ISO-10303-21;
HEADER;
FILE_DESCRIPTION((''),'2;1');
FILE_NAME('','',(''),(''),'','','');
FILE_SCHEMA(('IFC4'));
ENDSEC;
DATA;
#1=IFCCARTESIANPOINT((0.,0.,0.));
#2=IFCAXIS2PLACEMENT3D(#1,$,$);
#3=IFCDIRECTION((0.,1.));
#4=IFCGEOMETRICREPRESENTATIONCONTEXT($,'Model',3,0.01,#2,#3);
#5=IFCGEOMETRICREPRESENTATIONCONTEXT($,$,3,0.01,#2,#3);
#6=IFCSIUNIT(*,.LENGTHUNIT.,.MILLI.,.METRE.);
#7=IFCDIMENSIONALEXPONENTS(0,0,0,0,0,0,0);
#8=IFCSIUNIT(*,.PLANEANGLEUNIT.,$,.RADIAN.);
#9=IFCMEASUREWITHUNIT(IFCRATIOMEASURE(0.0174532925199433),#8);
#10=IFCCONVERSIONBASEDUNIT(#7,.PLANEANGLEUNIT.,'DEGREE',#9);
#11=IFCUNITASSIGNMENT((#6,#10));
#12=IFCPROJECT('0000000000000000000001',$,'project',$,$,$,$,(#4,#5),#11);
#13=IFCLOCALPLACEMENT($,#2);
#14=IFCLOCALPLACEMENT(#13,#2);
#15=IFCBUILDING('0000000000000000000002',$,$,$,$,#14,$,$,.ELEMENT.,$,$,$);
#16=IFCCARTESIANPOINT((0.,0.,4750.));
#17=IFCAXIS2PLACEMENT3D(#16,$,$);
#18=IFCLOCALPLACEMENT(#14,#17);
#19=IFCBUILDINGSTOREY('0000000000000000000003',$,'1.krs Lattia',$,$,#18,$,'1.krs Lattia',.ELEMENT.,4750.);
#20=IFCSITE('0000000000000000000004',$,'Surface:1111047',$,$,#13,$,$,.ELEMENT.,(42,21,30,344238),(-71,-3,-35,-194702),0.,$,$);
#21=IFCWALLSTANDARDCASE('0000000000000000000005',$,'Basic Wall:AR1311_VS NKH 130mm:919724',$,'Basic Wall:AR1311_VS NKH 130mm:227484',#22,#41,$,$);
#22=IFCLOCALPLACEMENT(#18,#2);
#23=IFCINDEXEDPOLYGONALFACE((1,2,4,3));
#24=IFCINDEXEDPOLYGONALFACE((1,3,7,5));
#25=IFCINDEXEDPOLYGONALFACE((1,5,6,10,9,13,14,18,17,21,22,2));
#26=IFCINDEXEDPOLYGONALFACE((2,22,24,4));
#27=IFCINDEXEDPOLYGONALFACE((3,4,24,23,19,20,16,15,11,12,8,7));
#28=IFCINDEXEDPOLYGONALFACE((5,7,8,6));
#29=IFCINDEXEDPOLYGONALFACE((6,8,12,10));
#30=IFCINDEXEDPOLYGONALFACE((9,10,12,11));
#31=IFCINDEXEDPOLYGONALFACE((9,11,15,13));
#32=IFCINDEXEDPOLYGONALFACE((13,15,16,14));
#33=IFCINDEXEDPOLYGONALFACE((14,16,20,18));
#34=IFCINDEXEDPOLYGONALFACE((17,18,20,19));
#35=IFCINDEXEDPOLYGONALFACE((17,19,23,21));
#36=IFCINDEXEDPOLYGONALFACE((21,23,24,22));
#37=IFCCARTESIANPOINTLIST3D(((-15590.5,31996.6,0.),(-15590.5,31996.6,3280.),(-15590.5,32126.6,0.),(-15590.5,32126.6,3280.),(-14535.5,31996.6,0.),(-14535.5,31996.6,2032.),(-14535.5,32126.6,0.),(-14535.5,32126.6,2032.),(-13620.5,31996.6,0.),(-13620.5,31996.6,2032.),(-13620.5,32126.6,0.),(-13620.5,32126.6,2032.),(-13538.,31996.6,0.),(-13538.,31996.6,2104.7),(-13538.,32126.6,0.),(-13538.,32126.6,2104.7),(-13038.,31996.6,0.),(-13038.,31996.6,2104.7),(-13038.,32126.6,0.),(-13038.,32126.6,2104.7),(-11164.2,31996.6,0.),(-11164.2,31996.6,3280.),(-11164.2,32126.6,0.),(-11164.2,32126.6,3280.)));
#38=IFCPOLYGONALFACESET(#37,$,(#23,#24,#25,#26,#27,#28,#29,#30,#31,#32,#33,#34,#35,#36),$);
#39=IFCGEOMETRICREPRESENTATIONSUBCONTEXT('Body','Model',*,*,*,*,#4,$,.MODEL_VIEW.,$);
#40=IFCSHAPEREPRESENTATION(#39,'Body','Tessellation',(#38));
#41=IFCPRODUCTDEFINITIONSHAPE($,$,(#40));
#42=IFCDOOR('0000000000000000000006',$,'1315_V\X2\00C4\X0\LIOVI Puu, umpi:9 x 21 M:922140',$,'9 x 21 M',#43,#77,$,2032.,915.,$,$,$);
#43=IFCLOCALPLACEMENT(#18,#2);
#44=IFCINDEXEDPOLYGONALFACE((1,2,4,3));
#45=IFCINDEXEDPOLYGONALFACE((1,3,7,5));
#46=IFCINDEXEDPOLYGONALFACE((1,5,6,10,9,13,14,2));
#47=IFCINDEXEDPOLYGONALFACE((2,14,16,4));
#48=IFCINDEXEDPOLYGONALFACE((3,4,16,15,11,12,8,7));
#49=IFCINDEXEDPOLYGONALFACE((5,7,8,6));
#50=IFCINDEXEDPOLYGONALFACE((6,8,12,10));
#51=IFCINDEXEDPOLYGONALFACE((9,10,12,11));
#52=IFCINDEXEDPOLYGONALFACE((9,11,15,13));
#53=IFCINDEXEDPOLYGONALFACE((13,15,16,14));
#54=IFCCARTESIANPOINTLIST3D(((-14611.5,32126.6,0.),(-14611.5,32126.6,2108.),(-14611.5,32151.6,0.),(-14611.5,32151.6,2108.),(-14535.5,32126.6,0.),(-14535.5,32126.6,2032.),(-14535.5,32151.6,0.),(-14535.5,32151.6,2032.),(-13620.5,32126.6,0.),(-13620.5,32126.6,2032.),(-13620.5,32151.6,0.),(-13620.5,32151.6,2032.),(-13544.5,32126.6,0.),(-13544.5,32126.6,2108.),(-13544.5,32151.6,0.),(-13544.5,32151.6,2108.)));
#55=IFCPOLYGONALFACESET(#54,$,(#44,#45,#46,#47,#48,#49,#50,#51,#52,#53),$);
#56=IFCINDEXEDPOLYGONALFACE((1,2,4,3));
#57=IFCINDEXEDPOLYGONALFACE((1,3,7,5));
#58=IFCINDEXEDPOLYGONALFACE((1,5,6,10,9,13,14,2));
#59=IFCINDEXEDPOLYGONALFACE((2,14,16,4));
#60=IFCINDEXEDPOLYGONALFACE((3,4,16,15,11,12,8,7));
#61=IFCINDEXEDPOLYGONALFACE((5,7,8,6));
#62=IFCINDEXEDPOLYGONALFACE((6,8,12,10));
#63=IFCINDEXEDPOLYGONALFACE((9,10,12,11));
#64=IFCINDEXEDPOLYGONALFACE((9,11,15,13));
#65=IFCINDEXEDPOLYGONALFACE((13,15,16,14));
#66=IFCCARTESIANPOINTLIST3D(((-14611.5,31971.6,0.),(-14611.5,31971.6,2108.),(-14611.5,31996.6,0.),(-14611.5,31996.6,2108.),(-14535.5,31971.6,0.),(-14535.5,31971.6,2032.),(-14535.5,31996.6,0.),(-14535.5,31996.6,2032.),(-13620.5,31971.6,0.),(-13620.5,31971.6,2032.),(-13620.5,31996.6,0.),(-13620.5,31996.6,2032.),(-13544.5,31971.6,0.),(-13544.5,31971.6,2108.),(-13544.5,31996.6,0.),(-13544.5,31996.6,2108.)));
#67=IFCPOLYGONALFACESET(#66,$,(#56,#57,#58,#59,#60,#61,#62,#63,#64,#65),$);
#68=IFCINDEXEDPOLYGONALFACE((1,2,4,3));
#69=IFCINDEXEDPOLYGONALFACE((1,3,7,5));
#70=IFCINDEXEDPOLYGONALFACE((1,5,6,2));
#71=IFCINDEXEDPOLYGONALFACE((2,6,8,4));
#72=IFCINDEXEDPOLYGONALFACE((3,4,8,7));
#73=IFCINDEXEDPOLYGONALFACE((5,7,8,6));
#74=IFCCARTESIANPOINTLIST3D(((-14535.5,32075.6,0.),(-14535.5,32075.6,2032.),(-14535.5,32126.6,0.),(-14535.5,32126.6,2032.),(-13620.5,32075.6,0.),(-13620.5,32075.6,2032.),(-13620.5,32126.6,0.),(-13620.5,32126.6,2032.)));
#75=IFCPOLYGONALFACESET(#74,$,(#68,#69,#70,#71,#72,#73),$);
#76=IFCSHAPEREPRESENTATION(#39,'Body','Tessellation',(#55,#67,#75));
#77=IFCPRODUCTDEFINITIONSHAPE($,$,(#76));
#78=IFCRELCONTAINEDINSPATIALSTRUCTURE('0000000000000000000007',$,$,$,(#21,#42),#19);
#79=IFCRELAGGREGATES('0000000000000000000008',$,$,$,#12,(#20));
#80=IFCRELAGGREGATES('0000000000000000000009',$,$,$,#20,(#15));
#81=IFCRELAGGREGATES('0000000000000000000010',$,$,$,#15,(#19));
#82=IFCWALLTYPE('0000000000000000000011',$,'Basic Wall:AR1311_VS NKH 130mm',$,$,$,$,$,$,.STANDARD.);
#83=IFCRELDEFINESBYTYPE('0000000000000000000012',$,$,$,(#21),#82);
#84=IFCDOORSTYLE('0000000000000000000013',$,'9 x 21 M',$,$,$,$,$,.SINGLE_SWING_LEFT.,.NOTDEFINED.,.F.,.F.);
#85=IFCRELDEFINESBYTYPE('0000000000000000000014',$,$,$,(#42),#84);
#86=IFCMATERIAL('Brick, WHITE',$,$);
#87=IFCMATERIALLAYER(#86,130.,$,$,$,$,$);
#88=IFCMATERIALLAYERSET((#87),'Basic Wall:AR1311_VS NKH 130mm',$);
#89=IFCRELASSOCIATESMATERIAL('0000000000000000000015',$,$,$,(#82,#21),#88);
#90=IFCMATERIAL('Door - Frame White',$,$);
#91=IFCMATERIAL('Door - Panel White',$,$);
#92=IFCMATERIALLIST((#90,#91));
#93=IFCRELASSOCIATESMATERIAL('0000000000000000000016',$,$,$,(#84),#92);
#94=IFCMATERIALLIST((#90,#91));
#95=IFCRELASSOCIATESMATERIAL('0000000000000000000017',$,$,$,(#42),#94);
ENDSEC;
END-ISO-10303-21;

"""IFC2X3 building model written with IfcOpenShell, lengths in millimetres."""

from ifc_helpers import new_model, entity, si_unit, converted_unit, direction, frame, frame_2d, origin, place, context, subcontext, project, spatial, polyline, rectangle, outline, extrude, clip, bounded_halfspace, source, transform, mapped, material, material_list, layer, layer_set, layer_usage, type_object, type_shapes, element, fill, save


model = new_model("IFC2X3")

# Units and contexts
model_context = context("Model", 3, precision=0.01, world=origin(), true_north=direction((0.0, 1.0)))
context_of_model = context(None, 3, precision=0.01, world=origin(), true_north=direction((0.0, 1.0)))
body_context = subcontext(model_context, "Body", "Model", "MODEL_VIEW")
ifc_project = project(units=[si_unit("LENGTHUNIT", "METRE", prefix="MILLI"), converted_unit("PLANEANGLEUNIT", "DEGREE", entity("IfcRatioMeasure", 0.0174532925199433), si_unit("PLANEANGLEUNIT", "RADIAN"), dimensions=[0, 0, 0, 0, 0, 0, 0])], contexts=[model_context, context_of_model])

# Site, building, storey
site_placement = place(None, origin())
site = spatial("IfcSite", under=ifc_project, at=site_placement, Name="Surface:1111047", CompositionType="ELEMENT", RefLatitude=(42, 21, 30, 344238), RefLongitude=(-71, -3, -35, -194702), RefElevation=0.0)
building_placement = place(site_placement, origin())
building = spatial("IfcBuilding", under=site, at=building_placement, CompositionType="ELEMENT")
storey_placement = place(building_placement, frame((0.0, 0.0, 4750.0)))
storey = spatial("IfcBuildingStorey", under=building, at=storey_placement, Name="1.krs Lattia", LongName="1.krs Lattia", CompositionType="ELEMENT", Elevation=4750.0)

# Shared definitions
ifc_material_1 = material(Name="Brick, WHITE")
ifc_layer = layer(ifc_material_1, 130.0)
ifc_layer_set = layer_set([ifc_layer], Name="Basic Wall:AR1311_VS NKH 130mm")
wall_type = type_object("IfcWallType", Name="Basic Wall:AR1311_VS NKH 130mm", PredefinedType="STANDARD", material=ifc_layer_set)

# Shared definitions
ifc_material_2 = material(Name="Door - Frame White")
ifc_material_3 = material(Name="Door - Panel White")
ifc_material_list_1 = material_list([ifc_material_2, ifc_material_3])
door_style_1 = type_object("IfcDoorStyle", Name="9 x 21 M", ConstructionType="NOTDEFINED", OperationType="SINGLE_SWING_LEFT", ParameterTakesPrecedence=False, Sizeable=False, material=ifc_material_list_1)
shared_shape_1 = source(origin(), body_context, "Body", "SweptSolid", [
    extrude(outline(polyline([(-533.5, -1073.0), (533.5, -1073.0), (533.5, 1035.0), (457.5, 1035.0), (457.5, -997.0), (-457.5, -997.0), (-457.5, 1035.0), (-533.5, 1035.0), (-533.5, -1073.0)])), frame((457.5, 155.0, 1035.0), z_axis=(0.0, -1.0, 0.0), x_axis=(-1.0, 0.0, 0.0)), (0.0, 0.0, 1.0), 25.0),
    extrude(outline(polyline([(-1073.0, -533.5), (1035.0, -533.5), (1035.0, -457.5), (-997.0, -457.5), (-997.0, 457.5), (1035.0, 457.5), (1035.0, 533.5), (-1073.0, 533.5), (-1073.0, -533.5)])), frame((457.5, 0.0, 1035.0), z_axis=(0.0, -1.0, 0.0), x_axis=(0.0, 0.0, -1.0)), (0.0, 0.0, 1.0), 25.0),
    extrude(rectangle(XDim=915.0, YDim=51.0, at=frame_2d((0.0, 0.0), x_axis=(1.0, 0.0))), frame((457.5, 104.5, 0.0)), (0.0, 0.0, 1.0), 2032.0),
])
type_shapes(door_style_1, [shared_shape_1])

# Wall, openings, door
ifc_layer_usage_1 = layer_usage(ifc_layer_set, "AXIS2", "NEGATIVE", 65.0)
wall_1_placement = place(storey_placement, frame((-15590.5, 32061.6, 0.0)))
wall_1 = element("IfcWallStandardCase", 1, at=wall_1_placement, inside=storey, type_object=wall_type, material=ifc_layer_usage_1, Name="Basic Wall:AR1311_VS NKH 130mm:919724", ObjectType="Basic Wall:AR1311_VS NKH 130mm:227484", context=body_context, shape_type="Clipping", body=[
    clip(extrude(rectangle(XDim=4426.3, YDim=130.0, at=frame_2d((2213.2, 0.0), x_axis=(-1.0, 0.0))), origin(), (0.0, 0.0, 1.0), 3280.0), bounded_halfspace(frame((0.0, -65.0, 3280.0), z_axis=(0.0, 0.0, -1.0), x_axis=(0.0, 1.0, 0.0)), True, frame((0.0, -65.0, 3280.0)), polyline([(0.0, 0.0), (4426.3, 0.0), (4426.3, 130.0), (0.0, 130.0), (0.0, 0.0)]))),
])
opening_1_placement = place(wall_1_placement, origin())
element("IfcOpeningElement", 2, at=opening_1_placement, cuts=wall_1, ObjectType="Opening", context=body_context, shape_type="SweptSolid", body=[
    extrude(rectangle(XDim=2105.7, YDim=500.0, at=frame_2d((0.0, 0.0), x_axis=(1.0, 0.0))), frame((2302.5, -65.0, 1051.8), z_axis=(0.0, 1.0, 0.0), x_axis=(0.0, 0.0, -1.0)), (0.0, 0.0, 1.0), 130.0),
])
opening_2_placement = place(wall_1_placement, frame((1055.0, -65.0, 0.0)))
opening_2 = element("IfcOpeningElement", 3, at=opening_2_placement, cuts=wall_1, ObjectType="Opening", context=body_context, shape_type="SweptSolid", body=[
    extrude(rectangle(XDim=915.0, YDim=2032.0, at=frame_2d((1016.0, 457.5), x_axis=(0.0, -1.0))), frame((0.0, 0.0, 0.0), z_axis=(0.0, 1.0, 0.0), x_axis=(0.0, 0.0, 1.0)), (0.0, 0.0, 1.0), 130.0),
])
ifc_material_list_2 = material_list([ifc_material_2, ifc_material_3])
door_1_placement = place(opening_2_placement, origin())
door_1 = element("IfcDoor", 4, at=door_1_placement, inside=storey, type_object=door_style_1, material=ifc_material_list_2, Name="1315_VÄLIOVI Puu, umpi:9 x 21 M:922140", ObjectType="9 x 21 M", OverallHeight=2032.0, OverallWidth=915.0, context=body_context, shape_type="MappedRepresentation", body=[
    mapped(shared_shape_1, transform((0.0, 0.0, 0.0), scale=1.0)),
])
fill(opening_2, door_1)

save(model, "model.ifc")
